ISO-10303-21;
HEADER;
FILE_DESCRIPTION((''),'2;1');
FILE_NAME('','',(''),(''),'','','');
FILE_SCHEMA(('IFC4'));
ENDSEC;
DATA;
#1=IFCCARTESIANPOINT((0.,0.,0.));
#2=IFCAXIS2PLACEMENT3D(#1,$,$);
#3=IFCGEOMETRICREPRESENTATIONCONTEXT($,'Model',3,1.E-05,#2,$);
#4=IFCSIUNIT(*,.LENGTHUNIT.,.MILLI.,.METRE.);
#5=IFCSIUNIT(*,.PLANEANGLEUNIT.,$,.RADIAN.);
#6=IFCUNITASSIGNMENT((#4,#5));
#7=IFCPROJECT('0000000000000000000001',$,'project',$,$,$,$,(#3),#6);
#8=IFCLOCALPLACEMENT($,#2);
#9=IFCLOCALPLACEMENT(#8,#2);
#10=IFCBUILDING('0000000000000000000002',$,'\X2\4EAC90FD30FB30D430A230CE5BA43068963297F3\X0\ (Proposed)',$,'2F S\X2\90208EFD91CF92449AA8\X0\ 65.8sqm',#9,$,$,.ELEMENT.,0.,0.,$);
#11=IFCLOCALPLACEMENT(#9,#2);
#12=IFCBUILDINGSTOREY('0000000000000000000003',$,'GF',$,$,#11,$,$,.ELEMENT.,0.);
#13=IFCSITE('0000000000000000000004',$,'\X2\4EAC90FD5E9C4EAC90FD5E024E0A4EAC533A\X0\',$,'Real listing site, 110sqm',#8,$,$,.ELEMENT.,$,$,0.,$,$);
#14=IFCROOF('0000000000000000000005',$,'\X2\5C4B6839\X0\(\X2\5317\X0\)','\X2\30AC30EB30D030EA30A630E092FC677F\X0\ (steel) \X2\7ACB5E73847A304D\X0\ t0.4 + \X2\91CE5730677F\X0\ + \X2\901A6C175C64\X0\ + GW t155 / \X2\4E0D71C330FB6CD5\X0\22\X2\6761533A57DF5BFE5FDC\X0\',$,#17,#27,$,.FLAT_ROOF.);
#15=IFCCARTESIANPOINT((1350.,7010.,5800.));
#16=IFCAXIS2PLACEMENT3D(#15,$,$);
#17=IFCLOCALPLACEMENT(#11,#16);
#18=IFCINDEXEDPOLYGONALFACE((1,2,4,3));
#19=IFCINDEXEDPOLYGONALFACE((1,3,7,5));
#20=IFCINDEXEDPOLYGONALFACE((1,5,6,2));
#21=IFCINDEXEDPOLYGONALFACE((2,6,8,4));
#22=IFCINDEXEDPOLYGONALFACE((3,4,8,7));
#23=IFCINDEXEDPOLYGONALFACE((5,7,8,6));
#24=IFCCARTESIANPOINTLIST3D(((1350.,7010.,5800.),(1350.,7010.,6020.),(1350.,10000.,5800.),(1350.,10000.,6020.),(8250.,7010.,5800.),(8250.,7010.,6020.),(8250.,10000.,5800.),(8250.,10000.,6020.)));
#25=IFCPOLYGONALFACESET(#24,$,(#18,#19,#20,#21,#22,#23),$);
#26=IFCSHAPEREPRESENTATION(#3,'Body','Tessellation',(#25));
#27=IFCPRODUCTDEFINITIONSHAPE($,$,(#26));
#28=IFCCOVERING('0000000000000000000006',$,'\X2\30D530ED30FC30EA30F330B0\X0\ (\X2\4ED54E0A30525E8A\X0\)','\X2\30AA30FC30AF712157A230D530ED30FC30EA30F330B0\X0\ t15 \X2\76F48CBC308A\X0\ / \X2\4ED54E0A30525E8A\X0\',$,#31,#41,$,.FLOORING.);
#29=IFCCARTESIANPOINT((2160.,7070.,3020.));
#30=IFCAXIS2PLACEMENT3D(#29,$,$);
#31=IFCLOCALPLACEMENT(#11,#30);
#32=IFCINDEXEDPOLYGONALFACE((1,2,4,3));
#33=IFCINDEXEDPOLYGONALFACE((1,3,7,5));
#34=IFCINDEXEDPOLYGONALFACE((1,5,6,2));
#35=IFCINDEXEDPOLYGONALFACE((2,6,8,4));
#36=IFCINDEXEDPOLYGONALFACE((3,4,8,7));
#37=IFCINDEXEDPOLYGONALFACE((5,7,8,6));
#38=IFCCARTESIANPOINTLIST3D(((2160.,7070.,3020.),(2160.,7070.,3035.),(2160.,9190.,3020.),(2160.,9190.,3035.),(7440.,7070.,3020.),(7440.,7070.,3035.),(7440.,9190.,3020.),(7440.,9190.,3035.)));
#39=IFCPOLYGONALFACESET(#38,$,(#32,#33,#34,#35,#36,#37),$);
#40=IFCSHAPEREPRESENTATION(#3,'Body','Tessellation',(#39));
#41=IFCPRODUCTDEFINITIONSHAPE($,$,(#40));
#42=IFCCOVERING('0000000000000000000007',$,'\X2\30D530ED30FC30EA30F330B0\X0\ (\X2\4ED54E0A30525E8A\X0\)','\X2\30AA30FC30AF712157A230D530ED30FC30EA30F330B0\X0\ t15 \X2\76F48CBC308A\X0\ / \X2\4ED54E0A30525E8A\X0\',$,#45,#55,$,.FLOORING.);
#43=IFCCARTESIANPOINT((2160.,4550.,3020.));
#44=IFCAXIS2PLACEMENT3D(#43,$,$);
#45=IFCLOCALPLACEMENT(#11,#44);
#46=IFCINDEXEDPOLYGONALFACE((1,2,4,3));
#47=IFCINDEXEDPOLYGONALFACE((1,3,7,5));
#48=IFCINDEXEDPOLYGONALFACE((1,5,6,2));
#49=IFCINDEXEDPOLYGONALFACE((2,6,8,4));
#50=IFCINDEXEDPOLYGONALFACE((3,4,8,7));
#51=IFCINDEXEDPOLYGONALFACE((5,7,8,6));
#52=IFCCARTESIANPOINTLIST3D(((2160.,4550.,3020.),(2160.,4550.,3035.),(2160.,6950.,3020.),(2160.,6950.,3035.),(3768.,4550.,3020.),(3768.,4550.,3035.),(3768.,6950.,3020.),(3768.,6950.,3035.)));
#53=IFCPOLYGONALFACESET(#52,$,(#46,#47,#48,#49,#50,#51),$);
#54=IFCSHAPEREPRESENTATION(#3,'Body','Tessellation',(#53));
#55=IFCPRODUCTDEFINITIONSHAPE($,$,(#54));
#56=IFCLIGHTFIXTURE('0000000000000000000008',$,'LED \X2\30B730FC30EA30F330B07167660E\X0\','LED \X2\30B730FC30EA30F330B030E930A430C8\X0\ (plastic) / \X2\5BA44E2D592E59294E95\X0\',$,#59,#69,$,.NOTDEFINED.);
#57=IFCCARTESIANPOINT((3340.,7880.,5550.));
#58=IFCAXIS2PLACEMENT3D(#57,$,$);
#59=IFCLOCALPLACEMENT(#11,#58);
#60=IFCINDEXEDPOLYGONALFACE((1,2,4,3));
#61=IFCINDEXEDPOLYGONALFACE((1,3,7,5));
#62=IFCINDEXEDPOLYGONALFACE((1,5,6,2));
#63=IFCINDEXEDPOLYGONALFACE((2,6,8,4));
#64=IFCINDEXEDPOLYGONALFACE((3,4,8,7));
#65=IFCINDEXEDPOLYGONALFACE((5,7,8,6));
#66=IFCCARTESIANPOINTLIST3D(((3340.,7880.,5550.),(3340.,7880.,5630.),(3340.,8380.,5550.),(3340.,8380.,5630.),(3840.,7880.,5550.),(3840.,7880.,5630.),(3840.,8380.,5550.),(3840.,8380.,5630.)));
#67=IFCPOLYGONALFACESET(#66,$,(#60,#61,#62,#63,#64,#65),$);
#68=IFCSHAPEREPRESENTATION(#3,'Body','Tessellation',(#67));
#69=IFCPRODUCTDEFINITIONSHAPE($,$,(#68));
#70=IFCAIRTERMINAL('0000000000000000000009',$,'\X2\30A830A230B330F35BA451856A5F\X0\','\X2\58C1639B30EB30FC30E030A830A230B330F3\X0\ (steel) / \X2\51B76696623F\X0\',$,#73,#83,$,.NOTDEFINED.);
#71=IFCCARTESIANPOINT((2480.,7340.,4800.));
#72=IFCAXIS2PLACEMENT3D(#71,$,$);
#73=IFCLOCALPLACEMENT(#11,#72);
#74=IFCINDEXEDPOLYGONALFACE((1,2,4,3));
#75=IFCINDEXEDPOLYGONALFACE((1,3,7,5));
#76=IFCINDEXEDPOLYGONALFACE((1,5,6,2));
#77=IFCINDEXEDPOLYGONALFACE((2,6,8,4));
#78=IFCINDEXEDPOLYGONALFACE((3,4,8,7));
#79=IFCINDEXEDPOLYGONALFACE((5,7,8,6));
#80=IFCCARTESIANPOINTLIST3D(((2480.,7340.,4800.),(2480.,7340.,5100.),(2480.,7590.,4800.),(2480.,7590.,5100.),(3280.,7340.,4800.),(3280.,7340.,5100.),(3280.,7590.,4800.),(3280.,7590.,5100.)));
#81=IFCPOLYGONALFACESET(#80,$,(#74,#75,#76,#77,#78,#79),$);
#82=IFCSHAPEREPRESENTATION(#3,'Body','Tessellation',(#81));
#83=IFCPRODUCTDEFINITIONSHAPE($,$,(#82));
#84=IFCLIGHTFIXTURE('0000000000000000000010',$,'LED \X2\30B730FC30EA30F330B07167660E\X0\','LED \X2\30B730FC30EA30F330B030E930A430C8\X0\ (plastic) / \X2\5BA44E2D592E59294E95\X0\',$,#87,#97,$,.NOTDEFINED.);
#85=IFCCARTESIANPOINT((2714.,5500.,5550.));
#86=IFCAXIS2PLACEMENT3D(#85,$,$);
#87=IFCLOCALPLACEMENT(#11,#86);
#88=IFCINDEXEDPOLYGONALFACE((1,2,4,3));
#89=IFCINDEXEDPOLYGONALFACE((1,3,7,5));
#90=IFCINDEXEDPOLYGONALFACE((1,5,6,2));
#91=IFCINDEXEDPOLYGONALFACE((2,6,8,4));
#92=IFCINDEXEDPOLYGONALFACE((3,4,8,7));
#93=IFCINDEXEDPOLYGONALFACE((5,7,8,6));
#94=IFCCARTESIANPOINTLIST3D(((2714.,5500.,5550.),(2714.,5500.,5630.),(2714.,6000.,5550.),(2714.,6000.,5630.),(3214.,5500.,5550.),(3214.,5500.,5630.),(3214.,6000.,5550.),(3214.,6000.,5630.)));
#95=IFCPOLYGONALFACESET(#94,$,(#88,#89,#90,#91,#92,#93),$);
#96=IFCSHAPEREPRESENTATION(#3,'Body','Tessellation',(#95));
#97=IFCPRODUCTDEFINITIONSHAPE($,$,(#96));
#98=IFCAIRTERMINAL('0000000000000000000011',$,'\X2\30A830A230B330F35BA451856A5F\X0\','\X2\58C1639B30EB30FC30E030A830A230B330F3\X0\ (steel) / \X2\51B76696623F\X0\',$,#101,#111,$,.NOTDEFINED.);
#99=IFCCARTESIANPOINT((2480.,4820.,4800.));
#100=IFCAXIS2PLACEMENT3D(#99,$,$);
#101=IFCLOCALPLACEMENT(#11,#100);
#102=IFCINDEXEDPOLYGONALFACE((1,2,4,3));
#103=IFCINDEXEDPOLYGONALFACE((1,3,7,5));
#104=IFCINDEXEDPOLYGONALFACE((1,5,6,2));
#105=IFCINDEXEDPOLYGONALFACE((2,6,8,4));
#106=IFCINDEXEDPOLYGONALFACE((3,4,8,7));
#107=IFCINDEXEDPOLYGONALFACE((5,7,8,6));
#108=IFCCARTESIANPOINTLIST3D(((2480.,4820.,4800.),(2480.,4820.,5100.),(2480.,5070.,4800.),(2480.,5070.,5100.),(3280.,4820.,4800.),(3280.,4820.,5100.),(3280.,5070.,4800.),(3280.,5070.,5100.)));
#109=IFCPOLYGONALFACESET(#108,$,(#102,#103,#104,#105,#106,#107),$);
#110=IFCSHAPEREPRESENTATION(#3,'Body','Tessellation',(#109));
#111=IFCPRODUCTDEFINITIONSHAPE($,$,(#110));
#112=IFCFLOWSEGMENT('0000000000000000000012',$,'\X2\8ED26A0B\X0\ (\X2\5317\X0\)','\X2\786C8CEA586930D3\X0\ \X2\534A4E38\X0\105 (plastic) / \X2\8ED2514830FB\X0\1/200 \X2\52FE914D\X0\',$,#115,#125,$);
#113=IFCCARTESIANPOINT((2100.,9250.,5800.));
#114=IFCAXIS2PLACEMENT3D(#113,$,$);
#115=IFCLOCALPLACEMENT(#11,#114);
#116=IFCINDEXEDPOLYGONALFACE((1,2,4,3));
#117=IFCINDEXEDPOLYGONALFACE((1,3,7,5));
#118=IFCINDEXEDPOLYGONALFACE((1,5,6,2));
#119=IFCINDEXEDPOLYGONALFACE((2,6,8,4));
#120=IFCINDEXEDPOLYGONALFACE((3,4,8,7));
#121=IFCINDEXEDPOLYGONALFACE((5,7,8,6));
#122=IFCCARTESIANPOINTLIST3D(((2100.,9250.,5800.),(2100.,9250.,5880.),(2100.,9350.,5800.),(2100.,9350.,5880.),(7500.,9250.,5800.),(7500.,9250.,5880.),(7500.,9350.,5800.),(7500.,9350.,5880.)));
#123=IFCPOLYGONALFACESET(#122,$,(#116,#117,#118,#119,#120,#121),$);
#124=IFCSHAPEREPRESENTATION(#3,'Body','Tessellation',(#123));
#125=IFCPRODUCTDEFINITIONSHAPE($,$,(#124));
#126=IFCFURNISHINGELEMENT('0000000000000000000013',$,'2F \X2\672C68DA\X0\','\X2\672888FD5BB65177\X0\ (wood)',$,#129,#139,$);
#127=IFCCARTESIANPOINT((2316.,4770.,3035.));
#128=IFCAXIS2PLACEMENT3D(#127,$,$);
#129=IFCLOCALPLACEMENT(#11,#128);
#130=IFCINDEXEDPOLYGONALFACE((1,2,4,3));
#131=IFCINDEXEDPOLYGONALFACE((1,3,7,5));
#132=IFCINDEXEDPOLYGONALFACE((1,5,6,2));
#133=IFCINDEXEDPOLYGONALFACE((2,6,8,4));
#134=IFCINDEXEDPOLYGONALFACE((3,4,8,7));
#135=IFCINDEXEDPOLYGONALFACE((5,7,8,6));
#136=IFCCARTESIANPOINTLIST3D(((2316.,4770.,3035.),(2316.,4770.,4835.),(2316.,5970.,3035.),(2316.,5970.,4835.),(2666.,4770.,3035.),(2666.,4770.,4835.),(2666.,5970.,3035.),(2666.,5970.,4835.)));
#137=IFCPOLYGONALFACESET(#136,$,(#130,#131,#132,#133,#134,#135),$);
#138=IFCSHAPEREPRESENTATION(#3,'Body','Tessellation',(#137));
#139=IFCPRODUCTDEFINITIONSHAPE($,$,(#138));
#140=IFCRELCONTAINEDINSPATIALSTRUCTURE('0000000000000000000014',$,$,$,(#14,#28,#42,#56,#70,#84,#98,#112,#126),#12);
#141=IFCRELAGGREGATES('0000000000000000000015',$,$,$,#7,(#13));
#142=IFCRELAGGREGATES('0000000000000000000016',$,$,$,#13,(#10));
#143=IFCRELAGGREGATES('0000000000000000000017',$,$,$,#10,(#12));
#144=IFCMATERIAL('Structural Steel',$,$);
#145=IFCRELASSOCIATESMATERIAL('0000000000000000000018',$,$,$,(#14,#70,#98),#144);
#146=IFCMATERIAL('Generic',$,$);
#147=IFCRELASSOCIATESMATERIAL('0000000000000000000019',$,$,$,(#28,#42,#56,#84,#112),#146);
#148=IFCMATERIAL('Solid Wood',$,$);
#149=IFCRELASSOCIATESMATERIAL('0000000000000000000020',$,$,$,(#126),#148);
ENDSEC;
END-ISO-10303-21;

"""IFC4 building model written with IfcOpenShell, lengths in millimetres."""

from ifc_helpers import new_model, si_unit, frame, frame_2d, origin, place, context, project, spatial, rectangle, extrude, material, element, save


model = new_model("IFC4")

# Units and contexts
model_context = context("Model", 3, precision=1e-05, world=origin())
ifc_project = project(units=[si_unit("LENGTHUNIT", "METRE", prefix="MILLI"), si_unit("PLANEANGLEUNIT", "RADIAN")], contexts=[model_context])

# Site, building, storey
site_placement = place(None, origin())
site = spatial("IfcSite", under=ifc_project, at=site_placement, Name="京都府京都市上京区", ObjectType="Real listing site, 110sqm", CompositionType="ELEMENT", RefElevation=0.0)
building_placement = place(site_placement, origin())
building = spatial("IfcBuilding", under=site, at=building_placement, Name="京都・ピアノ室と防音 (Proposed)", ObjectType="2F S造軽量鉄骨 65.8sqm", CompositionType="ELEMENT", ElevationOfRefHeight=0.0, ElevationOfTerrain=0.0)
storey_placement = place(building_placement, origin())
storey = spatial("IfcBuildingStorey", under=building, at=storey_placement, Name="GF", CompositionType="ELEMENT", Elevation=0.0)

# Shared definitions
ifc_material_1 = material(Name="Solid Wood")

# Roof
ifc_material_2 = material(Name="Structural Steel")
for number, where, name in (
    (1, (1350.0, 7010.0, 5800.0), "屋根(北)"),
):
    element("IfcRoof", number, at=place(storey_placement, frame(where)), inside=storey, material=ifc_material_2, Name=name, Description="ガルバリウム鋼板 (steel) 立平葺き t0.4 + 野地板 + 通気層 + GW t155 / 不燃・法22条区域対応", PredefinedType="FLAT_ROOF", context=model_context, shape_type="SweptSolid", body=[
        extrude(rectangle(XDim=6900.0, YDim=2990.0, at=frame_2d((3450.0, 1495.0))), frame((1350.0, 7010.0, 5800.0)), (0.0, 0.0, 1.0), 220.0),
    ])

# Coverings
ifc_material_3 = material(Name="Generic")
covering_1_placement = place(storey_placement, frame((2160.0, 7070.0, 3020.0)))
element("IfcCovering", 2, at=covering_1_placement, inside=storey, material=ifc_material_3, Name="フローリング (仕上げ床)", Description="オーク無垢フローリング t15 直貼り / 仕上げ床", PredefinedType="FLOORING", context=model_context, shape_type="SweptSolid", body=[
    extrude(rectangle(XDim=5280.0, YDim=2120.0, at=frame_2d((2640.0, 1060.0))), frame((2160.0, 7070.0, 3020.0)), (0.0, 0.0, 1.0), 15.0),
])
covering_2_placement = place(storey_placement, frame((2160.0, 4550.0, 3020.0)))
element("IfcCovering", 3, at=covering_2_placement, inside=storey, material=ifc_material_3, Name="フローリング (仕上げ床)", Description="オーク無垢フローリング t15 直貼り / 仕上げ床", PredefinedType="FLOORING", context=model_context, shape_type="SweptSolid", body=[
    extrude(rectangle(XDim=1608.0, YDim=2400.0, at=frame_2d((804.0, 1200.0))), frame((2160.0, 4550.0, 3020.0)), (0.0, 0.0, 1.0), 15.0),
])

# Light fixture
light_fixture_1_placement = place(storey_placement, frame((3340.0, 7880.0, 5550.0)))
element("IfcLightFixture", 4, at=light_fixture_1_placement, inside=storey, material=ifc_material_3, Name="LED シーリング照明", Description="LED シーリングライト (plastic) / 室中央天井", PredefinedType="NOTDEFINED", context=model_context, shape_type="SweptSolid", body=[
    extrude(rectangle(XDim=500.0, YDim=500.0, at=frame_2d((250.0, 250.0))), frame((3340.0, 7880.0, 5550.0)), (0.0, 0.0, 1.0), 80.0),
])

# Air terminal
air_terminal_1_placement = place(storey_placement, frame((2480.0, 7340.0, 4800.0)))
element("IfcAirTerminal", 5, at=air_terminal_1_placement, inside=storey, material=ifc_material_2, Name="エアコン室内機", Description="壁掛ルームエアコン (steel) / 冷暖房", PredefinedType="NOTDEFINED", context=model_context, shape_type="SweptSolid", body=[
    extrude(rectangle(XDim=800.0, YDim=250.0, at=frame_2d((400.0, 125.0))), frame((2480.0, 7340.0, 4800.0)), (0.0, 0.0, 1.0), 300.0),
])

# Light fixture
light_fixture_2_placement = place(storey_placement, frame((2714.0, 5500.0, 5550.0)))
element("IfcLightFixture", 6, at=light_fixture_2_placement, inside=storey, material=ifc_material_3, Name="LED シーリング照明", Description="LED シーリングライト (plastic) / 室中央天井", PredefinedType="NOTDEFINED", context=model_context, shape_type="SweptSolid", body=[
    extrude(rectangle(XDim=500.0, YDim=500.0, at=frame_2d((250.0, 250.0))), frame((2714.0, 5500.0, 5550.0)), (0.0, 0.0, 1.0), 80.0),
])

# Air terminal
air_terminal_2_placement = place(storey_placement, frame((2480.0, 4820.0, 4800.0)))
element("IfcAirTerminal", 7, at=air_terminal_2_placement, inside=storey, material=ifc_material_2, Name="エアコン室内機", Description="壁掛ルームエアコン (steel) / 冷暖房", PredefinedType="NOTDEFINED", context=model_context, shape_type="SweptSolid", body=[
    extrude(rectangle(XDim=800.0, YDim=250.0, at=frame_2d((400.0, 125.0))), frame((2480.0, 4820.0, 4800.0)), (0.0, 0.0, 1.0), 300.0),
])

# Flow segment
flow_segment_placement = place(storey_placement, frame((2100.0, 9250.0, 5800.0)))
element("IfcFlowSegment", 8, at=flow_segment_placement, inside=storey, material=ifc_material_3, Name="軒樋 (北)", Description="硬質塩ビ 半丸105 (plastic) / 軒先・1/200 勾配", context=model_context, shape_type="SweptSolid", body=[
    extrude(rectangle(XDim=5400.0, YDim=100.0, at=frame_2d((2700.0, 50.0))), frame((2100.0, 9250.0, 5800.0)), (0.0, 0.0, 1.0), 80.0),
])

# Furnishing element
furnishing_placement = place(storey_placement, frame((2316.0, 4770.0, 3035.0)))
element("IfcFurnishingElement", 9, at=furnishing_placement, inside=storey, material=ifc_material_1, Name="2F 本棚", Description="木製家具 (wood)", context=model_context, shape_type="SweptSolid", body=[
    extrude(rectangle(XDim=350.0, YDim=1200.0, at=frame_2d((175.0, 600.0))), frame((2316.0, 4770.0, 3035.0)), (0.0, 0.0, 1.0), 1800.0),
])

save(model, "model.ifc")
